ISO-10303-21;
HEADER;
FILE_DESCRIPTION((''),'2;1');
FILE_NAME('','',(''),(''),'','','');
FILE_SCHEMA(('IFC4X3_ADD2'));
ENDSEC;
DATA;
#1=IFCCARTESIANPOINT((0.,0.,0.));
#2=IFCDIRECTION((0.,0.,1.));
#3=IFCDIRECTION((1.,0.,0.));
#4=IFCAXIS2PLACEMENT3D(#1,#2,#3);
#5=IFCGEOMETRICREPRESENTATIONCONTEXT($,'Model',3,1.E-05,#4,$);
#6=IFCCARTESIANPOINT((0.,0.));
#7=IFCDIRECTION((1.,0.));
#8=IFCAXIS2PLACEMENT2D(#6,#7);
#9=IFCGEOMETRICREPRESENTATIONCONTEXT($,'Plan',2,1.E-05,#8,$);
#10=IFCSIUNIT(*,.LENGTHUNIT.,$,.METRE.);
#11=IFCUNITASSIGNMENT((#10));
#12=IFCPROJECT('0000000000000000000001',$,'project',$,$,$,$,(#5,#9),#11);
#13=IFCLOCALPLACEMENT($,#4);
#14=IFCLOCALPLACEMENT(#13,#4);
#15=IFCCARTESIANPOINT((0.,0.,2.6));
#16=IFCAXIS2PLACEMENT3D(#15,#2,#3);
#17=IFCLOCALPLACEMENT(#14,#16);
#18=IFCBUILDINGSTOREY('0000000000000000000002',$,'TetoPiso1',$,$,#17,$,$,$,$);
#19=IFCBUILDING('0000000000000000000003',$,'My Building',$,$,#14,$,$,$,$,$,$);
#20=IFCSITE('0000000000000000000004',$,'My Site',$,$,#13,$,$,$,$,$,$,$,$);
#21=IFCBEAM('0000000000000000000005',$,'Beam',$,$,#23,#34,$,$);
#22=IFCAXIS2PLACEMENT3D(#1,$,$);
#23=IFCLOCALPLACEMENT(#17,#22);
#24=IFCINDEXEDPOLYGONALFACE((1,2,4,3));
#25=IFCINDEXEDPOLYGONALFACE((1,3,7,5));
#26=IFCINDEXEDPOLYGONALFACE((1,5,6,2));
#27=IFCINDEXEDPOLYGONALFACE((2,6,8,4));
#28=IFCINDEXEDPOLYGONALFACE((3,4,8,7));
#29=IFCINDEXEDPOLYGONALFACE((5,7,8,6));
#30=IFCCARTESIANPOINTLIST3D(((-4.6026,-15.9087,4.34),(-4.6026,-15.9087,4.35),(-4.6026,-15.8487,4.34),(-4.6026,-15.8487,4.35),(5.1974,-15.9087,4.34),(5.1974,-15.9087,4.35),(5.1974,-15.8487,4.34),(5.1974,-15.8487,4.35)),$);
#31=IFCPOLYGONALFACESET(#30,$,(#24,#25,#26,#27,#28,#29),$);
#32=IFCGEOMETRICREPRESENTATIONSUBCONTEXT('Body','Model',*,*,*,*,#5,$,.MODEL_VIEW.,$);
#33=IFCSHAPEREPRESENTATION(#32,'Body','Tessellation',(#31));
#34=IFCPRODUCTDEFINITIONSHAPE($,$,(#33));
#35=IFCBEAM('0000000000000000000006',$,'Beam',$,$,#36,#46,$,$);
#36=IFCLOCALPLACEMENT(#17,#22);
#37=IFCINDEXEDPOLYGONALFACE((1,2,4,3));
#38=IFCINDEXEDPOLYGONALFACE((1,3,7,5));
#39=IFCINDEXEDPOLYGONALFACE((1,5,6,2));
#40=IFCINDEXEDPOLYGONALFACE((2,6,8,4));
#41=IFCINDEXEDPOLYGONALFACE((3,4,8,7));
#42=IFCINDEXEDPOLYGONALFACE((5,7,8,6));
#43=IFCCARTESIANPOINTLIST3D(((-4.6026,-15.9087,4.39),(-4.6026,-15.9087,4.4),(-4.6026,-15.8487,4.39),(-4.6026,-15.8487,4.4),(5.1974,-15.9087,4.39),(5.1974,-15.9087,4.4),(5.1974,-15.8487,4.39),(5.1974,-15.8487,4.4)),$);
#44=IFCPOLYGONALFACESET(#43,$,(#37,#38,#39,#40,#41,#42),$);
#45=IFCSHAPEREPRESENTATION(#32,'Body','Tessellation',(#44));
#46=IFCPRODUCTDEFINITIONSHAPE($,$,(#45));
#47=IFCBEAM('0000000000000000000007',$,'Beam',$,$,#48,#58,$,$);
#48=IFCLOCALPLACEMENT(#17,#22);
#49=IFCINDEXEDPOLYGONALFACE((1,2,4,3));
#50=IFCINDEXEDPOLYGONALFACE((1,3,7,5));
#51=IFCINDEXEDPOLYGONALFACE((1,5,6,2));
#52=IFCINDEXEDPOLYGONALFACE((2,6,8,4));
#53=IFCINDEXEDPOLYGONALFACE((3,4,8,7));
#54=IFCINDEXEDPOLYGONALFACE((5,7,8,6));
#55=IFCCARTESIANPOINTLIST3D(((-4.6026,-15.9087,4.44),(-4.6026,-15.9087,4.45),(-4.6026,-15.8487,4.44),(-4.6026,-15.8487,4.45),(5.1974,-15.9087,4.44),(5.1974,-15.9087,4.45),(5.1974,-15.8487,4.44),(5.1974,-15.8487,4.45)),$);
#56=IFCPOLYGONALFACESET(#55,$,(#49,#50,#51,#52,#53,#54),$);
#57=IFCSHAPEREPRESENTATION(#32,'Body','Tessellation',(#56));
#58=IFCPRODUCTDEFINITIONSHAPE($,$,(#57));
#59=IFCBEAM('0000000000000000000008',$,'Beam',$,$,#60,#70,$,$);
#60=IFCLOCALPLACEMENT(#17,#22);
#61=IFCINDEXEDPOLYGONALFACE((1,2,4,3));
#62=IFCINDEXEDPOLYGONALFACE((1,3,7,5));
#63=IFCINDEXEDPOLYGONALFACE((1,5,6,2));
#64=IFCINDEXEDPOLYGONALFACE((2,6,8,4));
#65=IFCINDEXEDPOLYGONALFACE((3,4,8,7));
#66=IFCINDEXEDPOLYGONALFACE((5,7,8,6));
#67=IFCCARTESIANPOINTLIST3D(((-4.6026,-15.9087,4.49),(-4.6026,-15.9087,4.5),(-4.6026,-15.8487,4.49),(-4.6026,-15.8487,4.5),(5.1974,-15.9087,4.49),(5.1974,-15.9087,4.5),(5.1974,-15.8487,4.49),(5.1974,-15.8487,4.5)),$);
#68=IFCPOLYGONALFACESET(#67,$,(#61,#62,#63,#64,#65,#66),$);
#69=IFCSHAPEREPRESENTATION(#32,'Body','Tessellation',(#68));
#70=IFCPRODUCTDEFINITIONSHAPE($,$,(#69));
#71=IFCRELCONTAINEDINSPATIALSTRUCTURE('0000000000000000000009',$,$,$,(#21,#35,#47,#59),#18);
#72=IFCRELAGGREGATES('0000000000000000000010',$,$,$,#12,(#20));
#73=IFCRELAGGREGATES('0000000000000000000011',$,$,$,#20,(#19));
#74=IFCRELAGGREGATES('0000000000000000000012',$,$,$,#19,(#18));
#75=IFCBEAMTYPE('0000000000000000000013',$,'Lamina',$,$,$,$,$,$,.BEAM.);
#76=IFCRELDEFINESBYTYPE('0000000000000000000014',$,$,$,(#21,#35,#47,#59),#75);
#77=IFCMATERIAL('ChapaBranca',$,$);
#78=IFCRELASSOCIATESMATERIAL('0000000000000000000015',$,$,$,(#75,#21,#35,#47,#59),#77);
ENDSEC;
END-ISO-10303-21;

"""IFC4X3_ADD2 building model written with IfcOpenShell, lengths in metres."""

from ifc_helpers import new_model, si_unit, frame, origin_with_axes, origin_2d, origin_2d_with_axis, place, context, subcontext, project, spatial, rectangle, extrude, material, material_profile, profile_set, profile_usage, type_object, element, save


model = new_model("IFC4X3_ADD2")

# Units and contexts
model_context = context("Model", 3, precision=1e-05, world=origin_with_axes())
plan_context = context("Plan", 2, precision=1e-05, world=origin_2d_with_axis())
body_context = subcontext(model_context, "Body", "Model", "MODEL_VIEW")
ifc_project = project(units=[si_unit("LENGTHUNIT", "METRE")], contexts=[model_context, plan_context])

# Site, building, storey
site_placement = place(None, origin_with_axes())
site = spatial("IfcSite", under=ifc_project, at=site_placement, Name="My Site")
building_placement = place(site_placement, origin_with_axes())
building = spatial("IfcBuilding", under=site, at=building_placement, Name="My Building")
storey_placement = place(building_placement, frame((0.0, 0.0, 2.6), z_axis=(0.0, 0.0, 1.0), x_axis=(1.0, 0.0, 0.0)))
storey = spatial("IfcBuildingStorey", under=building, at=storey_placement, Name="TetoPiso1")

# Beams
ifc_material = material(Name="ChapaBranca")
ifc_material_profile = material_profile(ifc_material, rectangle(XDim=0.06, YDim=0.01, at=origin_2d()))
ifc_profile_set = profile_set([ifc_material_profile])
beam_type = type_object("IfcBeamType", Name="Lamina", PredefinedType="BEAM", material=ifc_profile_set)
ifc_profile_usage_1 = profile_usage(ifc_profile_set, cardinal=5)
beam_1_placement = place(storey_placement, frame((-4.6026, -15.8787, 4.345), z_axis=(1.0, 0.0, 0.0), x_axis=(0.0, 1.0, 0.0)))
element("IfcBeam", 1, at=beam_1_placement, inside=storey, type_object=beam_type, material=ifc_profile_usage_1, Name="Beam", context=body_context, shape_type="SweptSolid", body=[
    extrude(rectangle(XDim=0.06, YDim=0.01, at=origin_2d()), origin_with_axes(), (0.0, 0.0, 1.0), 9.8),
])
ifc_profile_usage_2 = profile_usage(ifc_profile_set, cardinal=5)
beam_2_placement = place(storey_placement, frame((-4.6026, -15.8787, 4.395), z_axis=(1.0, 0.0, 0.0), x_axis=(0.0, 1.0, 0.0)))
element("IfcBeam", 2, at=beam_2_placement, inside=storey, type_object=beam_type, material=ifc_profile_usage_2, Name="Beam", context=body_context, shape_type="SweptSolid", body=[
    extrude(rectangle(XDim=0.06, YDim=0.01, at=origin_2d()), origin_with_axes(), (0.0, 0.0, 1.0), 9.8),
])
ifc_profile_usage_3 = profile_usage(ifc_profile_set, cardinal=5)
beam_3_placement = place(storey_placement, frame((-4.6026, -15.8787, 4.445), z_axis=(1.0, 0.0, 0.0), x_axis=(0.0, 1.0, 0.0)))
element("IfcBeam", 3, at=beam_3_placement, inside=storey, type_object=beam_type, material=ifc_profile_usage_3, Name="Beam", context=body_context, shape_type="SweptSolid", body=[
    extrude(rectangle(XDim=0.06, YDim=0.01, at=origin_2d()), origin_with_axes(), (0.0, 0.0, 1.0), 9.8),
])
ifc_profile_usage_4 = profile_usage(ifc_profile_set, cardinal=5)
beam_4_placement = place(storey_placement, frame((-4.6026, -15.8787, 4.495), z_axis=(1.0, 0.0, 0.0), x_axis=(0.0, 1.0, 0.0)))
element("IfcBeam", 4, at=beam_4_placement, inside=storey, type_object=beam_type, material=ifc_profile_usage_4, Name="Beam", context=body_context, shape_type="SweptSolid", body=[
    extrude(rectangle(XDim=0.06, YDim=0.01, at=origin_2d()), origin_with_axes(), (0.0, 0.0, 1.0), 9.8),
])

save(model, "model.ifc")
